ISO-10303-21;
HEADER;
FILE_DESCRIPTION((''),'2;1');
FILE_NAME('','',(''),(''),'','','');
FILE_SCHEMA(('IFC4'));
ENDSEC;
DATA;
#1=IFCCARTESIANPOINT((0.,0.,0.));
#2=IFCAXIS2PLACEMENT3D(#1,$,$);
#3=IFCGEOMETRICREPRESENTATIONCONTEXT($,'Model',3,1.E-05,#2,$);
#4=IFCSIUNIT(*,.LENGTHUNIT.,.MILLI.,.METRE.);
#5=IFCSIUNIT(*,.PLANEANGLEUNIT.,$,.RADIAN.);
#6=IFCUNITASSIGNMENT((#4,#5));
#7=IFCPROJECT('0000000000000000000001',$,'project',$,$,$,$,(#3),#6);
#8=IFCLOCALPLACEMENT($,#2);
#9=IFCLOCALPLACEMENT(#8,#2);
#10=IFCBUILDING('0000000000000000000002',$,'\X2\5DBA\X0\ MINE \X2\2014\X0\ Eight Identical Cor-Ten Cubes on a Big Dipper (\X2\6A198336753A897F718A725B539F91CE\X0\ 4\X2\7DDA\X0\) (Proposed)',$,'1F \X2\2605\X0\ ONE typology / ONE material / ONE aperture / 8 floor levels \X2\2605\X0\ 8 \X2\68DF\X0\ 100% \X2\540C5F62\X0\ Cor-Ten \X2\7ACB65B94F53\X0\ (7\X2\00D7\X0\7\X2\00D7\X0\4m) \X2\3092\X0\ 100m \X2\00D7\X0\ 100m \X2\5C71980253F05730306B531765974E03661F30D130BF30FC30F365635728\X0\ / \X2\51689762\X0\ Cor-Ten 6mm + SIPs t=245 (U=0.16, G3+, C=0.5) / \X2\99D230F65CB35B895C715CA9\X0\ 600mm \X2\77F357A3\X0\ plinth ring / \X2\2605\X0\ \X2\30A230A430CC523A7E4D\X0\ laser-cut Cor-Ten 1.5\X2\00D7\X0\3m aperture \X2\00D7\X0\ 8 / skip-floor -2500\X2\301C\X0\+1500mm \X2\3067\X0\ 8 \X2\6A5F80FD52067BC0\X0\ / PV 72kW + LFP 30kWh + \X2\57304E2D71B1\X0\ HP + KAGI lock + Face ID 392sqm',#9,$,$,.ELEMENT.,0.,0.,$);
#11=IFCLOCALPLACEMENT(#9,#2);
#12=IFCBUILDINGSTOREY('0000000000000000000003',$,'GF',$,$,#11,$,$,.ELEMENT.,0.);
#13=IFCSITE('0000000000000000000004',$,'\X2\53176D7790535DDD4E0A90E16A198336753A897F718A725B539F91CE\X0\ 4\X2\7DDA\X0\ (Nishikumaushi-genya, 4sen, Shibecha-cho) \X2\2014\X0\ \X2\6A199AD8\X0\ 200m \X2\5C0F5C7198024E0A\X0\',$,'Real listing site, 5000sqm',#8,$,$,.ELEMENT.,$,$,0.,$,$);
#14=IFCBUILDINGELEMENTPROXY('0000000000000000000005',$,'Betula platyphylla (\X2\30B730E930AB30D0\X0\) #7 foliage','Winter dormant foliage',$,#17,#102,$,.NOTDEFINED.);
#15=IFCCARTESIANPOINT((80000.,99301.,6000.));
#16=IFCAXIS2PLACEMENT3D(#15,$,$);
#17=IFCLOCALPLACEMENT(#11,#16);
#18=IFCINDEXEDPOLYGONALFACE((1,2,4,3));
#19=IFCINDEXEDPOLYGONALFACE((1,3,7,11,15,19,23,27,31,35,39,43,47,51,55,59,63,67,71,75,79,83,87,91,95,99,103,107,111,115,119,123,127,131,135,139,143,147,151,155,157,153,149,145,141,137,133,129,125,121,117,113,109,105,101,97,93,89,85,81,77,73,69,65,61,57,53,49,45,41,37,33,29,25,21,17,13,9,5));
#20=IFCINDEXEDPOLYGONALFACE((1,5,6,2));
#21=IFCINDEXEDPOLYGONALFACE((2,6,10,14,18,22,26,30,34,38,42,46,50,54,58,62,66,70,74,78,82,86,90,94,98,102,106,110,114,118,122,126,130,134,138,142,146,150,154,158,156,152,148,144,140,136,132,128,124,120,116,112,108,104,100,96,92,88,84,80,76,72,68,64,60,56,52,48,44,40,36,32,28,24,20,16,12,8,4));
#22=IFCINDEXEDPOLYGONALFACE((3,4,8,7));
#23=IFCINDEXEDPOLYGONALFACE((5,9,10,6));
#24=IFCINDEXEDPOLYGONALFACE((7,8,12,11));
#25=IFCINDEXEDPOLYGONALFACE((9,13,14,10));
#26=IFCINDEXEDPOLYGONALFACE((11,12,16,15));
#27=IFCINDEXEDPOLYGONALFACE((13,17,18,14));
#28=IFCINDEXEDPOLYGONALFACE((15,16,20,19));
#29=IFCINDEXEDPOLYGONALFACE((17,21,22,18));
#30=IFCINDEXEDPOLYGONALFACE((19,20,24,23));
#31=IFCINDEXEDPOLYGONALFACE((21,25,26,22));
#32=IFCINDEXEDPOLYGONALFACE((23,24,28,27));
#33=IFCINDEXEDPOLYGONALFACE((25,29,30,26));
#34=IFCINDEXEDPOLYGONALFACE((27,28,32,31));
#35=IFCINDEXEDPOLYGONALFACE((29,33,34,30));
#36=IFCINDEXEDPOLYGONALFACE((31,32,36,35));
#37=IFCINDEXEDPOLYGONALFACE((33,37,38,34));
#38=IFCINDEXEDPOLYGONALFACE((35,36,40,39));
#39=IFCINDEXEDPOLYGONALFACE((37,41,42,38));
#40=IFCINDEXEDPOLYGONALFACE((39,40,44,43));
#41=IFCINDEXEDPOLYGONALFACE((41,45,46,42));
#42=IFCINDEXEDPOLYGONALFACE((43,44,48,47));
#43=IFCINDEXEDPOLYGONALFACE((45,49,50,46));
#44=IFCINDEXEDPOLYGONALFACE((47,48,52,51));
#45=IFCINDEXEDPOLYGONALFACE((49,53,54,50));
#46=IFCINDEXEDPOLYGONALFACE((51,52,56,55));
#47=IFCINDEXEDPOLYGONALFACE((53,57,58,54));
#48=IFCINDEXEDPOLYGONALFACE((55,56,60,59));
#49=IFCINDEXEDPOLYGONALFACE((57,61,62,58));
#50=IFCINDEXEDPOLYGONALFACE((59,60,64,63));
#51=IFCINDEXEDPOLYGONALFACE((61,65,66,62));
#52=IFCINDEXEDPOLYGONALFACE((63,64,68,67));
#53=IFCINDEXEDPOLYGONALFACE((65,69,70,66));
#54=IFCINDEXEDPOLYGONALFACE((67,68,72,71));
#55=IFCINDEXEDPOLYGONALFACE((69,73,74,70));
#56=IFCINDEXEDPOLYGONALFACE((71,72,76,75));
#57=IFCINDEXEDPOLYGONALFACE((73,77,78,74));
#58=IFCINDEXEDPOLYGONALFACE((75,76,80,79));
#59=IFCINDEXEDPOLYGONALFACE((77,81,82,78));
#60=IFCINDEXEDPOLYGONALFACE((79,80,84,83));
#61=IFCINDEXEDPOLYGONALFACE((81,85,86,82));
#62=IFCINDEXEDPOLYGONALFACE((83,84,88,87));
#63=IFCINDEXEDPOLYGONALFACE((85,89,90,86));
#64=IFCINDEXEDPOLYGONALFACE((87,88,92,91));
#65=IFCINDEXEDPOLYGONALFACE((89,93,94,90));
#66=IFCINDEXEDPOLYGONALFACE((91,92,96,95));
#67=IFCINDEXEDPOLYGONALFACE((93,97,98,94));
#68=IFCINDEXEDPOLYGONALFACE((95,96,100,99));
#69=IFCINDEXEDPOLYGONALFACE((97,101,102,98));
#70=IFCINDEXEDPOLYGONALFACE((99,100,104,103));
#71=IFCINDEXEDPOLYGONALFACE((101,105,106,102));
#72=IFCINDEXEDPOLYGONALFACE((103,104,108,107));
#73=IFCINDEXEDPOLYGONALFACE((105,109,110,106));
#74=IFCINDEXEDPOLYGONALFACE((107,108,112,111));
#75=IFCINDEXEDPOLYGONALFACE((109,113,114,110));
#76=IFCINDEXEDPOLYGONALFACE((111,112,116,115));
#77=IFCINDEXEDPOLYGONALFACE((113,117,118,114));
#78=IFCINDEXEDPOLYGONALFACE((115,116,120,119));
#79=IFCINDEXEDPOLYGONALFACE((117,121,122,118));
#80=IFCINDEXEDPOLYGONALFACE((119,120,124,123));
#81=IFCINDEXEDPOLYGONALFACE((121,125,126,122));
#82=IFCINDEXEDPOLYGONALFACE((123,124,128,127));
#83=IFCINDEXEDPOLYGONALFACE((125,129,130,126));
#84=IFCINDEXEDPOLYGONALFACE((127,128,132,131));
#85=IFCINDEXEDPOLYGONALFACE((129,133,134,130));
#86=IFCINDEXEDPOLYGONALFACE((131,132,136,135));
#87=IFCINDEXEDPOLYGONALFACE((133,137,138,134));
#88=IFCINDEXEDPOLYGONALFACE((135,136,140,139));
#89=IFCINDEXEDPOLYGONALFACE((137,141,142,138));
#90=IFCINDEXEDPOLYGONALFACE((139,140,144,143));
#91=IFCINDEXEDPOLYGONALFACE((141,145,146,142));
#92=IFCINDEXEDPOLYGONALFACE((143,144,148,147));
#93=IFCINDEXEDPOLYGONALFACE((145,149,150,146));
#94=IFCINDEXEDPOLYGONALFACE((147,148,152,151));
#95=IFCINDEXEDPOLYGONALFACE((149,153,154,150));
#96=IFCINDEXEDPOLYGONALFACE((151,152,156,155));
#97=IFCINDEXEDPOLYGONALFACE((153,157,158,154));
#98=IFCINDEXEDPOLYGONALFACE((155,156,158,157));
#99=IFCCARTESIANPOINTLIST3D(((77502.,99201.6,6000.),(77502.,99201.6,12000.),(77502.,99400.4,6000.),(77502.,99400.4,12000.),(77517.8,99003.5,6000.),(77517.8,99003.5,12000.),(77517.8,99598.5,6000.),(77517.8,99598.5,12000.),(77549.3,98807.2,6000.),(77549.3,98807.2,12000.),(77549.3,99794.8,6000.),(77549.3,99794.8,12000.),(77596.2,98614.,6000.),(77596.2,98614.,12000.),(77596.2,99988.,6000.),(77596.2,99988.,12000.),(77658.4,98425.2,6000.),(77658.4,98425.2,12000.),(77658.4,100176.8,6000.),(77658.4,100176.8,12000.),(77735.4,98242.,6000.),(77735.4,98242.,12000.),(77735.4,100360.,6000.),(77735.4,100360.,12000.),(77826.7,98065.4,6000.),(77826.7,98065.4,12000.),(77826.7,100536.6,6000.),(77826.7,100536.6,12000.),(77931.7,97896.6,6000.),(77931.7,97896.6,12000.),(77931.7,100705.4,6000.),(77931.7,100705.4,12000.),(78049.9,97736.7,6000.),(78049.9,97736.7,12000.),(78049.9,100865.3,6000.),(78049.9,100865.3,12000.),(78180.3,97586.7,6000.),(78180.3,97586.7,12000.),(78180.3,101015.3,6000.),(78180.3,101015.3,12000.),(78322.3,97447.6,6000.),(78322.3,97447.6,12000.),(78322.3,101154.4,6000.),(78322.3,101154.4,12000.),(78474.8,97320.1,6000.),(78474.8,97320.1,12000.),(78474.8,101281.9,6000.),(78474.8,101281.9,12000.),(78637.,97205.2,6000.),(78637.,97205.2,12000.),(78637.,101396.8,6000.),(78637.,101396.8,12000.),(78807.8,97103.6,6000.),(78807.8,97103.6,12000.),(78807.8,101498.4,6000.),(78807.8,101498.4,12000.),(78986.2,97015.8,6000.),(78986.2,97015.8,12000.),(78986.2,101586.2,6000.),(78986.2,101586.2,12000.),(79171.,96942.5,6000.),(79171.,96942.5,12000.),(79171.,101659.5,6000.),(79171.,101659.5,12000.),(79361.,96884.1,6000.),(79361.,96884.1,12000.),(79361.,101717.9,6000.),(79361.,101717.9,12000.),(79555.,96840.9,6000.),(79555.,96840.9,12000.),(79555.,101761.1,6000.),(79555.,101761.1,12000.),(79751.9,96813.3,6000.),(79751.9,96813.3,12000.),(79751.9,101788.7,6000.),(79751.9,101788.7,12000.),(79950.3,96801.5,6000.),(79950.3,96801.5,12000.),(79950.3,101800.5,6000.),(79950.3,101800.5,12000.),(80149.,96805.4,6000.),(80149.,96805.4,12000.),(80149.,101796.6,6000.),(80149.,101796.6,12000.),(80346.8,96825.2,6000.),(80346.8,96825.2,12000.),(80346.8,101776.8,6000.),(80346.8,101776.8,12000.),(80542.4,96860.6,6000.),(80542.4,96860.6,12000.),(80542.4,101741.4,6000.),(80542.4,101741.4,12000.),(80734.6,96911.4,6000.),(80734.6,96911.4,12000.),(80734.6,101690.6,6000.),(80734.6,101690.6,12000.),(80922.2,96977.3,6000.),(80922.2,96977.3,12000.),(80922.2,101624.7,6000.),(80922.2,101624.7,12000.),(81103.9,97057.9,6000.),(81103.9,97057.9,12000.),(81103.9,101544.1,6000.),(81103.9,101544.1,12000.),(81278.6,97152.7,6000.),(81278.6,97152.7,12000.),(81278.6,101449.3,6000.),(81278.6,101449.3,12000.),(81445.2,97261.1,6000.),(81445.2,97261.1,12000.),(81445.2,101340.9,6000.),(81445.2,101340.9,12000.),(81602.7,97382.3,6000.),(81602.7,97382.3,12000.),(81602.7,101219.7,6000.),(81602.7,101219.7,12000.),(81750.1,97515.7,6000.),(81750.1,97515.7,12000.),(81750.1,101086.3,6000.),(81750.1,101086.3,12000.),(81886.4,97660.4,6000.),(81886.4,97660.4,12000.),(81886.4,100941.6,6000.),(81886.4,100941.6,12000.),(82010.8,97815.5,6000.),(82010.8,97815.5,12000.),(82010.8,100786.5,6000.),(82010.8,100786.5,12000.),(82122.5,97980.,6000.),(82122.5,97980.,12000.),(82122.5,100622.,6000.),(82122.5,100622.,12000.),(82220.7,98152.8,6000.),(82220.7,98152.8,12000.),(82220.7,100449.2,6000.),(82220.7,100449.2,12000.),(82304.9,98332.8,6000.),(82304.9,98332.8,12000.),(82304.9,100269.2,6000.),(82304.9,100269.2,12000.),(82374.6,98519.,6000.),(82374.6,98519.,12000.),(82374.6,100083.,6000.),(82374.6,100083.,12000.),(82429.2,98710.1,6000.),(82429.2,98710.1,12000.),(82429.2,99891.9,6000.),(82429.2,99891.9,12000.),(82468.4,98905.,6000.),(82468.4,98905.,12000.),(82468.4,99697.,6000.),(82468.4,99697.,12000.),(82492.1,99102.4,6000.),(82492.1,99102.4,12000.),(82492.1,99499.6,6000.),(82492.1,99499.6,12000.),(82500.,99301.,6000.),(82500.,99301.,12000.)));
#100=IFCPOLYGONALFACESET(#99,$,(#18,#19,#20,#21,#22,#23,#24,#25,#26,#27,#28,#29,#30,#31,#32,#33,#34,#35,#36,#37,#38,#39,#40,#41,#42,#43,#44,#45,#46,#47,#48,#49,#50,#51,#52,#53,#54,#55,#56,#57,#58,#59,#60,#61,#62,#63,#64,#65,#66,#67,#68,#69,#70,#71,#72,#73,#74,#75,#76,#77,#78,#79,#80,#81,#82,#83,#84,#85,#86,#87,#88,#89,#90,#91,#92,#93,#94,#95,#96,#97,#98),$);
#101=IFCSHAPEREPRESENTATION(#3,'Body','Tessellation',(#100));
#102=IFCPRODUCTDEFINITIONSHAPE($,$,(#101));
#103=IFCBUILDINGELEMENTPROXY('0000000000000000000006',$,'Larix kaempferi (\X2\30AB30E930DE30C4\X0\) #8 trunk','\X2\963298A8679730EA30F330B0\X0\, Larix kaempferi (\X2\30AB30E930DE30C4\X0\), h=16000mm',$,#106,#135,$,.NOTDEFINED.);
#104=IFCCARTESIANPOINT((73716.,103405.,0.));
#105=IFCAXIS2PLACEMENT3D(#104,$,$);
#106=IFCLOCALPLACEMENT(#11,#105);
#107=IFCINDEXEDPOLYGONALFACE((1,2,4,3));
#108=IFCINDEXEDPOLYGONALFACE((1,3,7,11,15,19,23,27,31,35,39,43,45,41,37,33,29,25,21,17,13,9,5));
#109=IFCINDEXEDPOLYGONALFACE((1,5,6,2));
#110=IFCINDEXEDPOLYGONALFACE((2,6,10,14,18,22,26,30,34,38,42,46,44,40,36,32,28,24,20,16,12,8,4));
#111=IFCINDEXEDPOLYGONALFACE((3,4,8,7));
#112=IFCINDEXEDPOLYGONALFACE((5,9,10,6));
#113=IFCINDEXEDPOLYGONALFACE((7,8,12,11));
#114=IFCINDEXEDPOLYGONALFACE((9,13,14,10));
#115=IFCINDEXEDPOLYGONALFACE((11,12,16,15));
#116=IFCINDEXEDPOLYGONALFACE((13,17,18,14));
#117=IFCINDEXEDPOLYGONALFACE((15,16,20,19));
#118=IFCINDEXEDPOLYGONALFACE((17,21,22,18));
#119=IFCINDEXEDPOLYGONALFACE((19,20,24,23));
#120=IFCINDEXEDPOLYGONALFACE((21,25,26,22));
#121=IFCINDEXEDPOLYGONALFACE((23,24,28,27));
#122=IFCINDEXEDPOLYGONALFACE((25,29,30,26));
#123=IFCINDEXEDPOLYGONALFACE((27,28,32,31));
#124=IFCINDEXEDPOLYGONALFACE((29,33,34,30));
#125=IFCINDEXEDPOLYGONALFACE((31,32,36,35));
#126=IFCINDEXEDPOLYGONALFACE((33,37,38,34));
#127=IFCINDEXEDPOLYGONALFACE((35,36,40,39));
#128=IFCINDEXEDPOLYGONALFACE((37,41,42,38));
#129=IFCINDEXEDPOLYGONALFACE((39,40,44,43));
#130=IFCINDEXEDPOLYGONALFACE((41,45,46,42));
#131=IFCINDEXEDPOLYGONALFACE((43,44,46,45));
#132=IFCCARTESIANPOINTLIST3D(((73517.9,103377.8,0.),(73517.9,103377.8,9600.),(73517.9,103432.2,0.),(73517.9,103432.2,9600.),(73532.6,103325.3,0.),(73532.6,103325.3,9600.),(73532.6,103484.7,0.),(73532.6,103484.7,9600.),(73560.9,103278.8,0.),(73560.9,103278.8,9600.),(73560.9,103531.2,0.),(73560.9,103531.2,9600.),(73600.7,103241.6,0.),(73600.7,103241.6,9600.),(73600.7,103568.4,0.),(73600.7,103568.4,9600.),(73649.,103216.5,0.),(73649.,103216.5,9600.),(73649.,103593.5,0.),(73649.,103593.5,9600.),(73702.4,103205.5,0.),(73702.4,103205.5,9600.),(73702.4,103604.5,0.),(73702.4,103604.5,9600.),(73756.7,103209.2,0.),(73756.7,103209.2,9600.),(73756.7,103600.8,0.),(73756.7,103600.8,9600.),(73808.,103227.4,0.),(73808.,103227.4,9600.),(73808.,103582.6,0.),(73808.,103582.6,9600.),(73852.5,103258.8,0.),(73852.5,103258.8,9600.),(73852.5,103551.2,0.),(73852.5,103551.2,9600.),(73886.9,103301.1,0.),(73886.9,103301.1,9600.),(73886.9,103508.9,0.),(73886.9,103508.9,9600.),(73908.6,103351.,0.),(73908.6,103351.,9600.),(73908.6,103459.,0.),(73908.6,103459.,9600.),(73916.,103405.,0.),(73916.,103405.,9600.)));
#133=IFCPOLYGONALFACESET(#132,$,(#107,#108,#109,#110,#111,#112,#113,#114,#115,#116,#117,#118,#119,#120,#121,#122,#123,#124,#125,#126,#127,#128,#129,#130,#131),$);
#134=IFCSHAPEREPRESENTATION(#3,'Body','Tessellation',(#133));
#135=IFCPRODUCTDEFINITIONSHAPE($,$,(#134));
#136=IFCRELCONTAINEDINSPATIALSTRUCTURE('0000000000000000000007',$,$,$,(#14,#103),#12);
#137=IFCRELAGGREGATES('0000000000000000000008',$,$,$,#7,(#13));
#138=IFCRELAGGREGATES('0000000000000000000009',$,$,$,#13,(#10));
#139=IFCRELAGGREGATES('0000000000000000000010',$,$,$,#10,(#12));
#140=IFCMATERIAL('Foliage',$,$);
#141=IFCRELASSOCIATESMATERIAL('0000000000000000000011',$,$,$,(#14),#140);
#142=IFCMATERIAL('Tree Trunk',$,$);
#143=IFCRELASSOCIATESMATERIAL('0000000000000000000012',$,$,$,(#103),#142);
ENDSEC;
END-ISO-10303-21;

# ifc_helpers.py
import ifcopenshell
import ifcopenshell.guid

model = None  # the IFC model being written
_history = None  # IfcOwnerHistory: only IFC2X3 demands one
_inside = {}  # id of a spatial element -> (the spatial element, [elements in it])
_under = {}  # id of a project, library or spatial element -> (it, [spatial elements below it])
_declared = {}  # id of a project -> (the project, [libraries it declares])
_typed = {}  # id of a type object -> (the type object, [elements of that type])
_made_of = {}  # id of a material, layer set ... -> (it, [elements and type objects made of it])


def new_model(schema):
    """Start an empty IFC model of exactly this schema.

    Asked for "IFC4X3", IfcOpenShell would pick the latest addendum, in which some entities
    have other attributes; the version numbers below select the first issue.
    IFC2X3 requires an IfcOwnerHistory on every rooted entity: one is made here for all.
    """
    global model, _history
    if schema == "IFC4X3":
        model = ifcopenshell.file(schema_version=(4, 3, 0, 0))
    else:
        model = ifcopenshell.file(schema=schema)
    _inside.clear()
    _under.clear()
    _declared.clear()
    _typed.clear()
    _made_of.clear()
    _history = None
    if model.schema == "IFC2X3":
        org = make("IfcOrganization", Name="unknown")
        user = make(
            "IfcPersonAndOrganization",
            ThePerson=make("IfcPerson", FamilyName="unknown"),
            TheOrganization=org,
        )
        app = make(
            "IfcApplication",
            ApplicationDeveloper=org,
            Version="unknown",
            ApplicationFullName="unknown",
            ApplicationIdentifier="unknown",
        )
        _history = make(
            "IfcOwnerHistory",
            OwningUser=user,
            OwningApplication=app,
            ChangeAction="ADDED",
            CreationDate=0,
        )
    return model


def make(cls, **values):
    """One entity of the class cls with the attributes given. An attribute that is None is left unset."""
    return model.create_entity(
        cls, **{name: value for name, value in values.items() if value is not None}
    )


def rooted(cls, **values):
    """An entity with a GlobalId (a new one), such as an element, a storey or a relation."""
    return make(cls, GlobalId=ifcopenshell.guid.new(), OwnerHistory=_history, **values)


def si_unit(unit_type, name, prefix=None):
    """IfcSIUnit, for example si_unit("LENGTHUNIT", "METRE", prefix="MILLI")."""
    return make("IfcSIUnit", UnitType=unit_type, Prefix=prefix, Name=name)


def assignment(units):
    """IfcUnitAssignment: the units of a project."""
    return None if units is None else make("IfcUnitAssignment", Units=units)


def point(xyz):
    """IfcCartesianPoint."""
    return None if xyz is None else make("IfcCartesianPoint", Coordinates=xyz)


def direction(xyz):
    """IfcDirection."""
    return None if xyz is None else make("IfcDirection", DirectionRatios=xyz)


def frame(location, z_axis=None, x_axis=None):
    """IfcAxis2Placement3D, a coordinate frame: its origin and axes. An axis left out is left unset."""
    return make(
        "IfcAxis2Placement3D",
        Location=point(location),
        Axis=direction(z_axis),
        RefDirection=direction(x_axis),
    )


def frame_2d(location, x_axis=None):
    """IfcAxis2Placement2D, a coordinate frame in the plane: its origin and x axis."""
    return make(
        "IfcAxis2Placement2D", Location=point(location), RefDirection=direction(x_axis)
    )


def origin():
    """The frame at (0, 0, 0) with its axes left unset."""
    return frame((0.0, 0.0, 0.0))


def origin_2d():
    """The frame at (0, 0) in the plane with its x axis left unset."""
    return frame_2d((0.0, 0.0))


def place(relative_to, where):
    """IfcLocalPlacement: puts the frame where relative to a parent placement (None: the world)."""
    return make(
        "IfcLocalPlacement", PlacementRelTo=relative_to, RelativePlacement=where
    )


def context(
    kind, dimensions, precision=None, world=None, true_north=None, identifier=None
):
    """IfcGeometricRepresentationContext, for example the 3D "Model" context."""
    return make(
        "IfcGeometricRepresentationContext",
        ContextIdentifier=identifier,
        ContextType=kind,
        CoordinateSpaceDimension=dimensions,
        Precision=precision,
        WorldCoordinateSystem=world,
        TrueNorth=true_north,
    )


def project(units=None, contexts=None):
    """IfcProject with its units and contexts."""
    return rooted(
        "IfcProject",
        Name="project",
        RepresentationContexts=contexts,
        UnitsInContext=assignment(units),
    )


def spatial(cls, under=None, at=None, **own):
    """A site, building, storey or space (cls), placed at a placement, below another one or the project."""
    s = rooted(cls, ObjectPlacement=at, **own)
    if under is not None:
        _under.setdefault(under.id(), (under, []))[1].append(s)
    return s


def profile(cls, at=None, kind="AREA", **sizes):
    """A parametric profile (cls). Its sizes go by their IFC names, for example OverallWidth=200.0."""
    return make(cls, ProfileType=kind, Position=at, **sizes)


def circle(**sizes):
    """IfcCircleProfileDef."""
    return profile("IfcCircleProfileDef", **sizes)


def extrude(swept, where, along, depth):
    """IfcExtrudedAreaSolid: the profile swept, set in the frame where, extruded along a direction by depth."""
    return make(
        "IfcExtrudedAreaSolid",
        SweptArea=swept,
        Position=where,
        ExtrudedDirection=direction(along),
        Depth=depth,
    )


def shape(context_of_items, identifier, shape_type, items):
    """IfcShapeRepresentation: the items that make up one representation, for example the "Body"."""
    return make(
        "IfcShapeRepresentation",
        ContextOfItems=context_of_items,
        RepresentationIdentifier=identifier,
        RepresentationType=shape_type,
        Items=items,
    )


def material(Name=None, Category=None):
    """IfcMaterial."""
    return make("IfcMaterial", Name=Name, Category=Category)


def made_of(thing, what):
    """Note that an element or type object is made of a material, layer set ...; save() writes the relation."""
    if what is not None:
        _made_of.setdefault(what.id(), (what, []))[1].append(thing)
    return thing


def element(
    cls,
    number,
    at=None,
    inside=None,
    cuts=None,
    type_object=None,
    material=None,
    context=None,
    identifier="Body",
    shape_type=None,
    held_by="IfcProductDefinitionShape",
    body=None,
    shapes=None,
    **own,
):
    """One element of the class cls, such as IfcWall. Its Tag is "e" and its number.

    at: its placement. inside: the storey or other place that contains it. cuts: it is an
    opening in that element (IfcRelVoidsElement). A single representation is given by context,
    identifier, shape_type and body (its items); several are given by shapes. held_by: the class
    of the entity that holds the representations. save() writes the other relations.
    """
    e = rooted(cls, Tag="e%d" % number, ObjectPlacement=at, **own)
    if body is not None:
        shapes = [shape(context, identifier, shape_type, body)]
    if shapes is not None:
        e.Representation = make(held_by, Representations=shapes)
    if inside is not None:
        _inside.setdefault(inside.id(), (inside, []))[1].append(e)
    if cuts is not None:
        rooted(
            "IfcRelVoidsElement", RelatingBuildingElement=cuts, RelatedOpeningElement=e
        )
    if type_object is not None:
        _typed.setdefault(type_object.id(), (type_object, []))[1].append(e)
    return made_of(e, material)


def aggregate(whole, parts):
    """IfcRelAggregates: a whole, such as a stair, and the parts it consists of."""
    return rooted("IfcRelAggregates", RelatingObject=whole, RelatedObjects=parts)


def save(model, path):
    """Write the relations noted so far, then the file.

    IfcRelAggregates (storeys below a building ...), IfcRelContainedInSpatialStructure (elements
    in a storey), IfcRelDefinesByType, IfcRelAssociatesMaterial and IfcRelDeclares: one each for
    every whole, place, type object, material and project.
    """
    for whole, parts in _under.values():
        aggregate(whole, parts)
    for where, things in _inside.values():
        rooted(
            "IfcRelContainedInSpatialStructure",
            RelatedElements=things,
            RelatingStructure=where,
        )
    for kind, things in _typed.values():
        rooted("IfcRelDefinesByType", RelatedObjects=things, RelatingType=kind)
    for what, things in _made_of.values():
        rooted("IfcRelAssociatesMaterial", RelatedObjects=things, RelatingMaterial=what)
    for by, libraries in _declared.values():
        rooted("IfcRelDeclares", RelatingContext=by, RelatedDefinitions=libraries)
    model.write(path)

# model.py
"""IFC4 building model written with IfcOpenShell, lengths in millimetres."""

from ifc_helpers import new_model, si_unit, frame, origin, origin_2d, place, context, project, spatial, circle, extrude, material, element, save


model = new_model("IFC4")

# Units and contexts
model_context = context("Model", 3, precision=1e-05, world=origin())
ifc_project = project(units=[si_unit("LENGTHUNIT", "METRE", prefix="MILLI"), si_unit("PLANEANGLEUNIT", "RADIAN")], contexts=[model_context])

# Site, building, storey
site_placement = place(None, origin())
site = spatial("IfcSite", under=ifc_project, at=site_placement, Name="北海道川上郡標茶町西熊牛原野 4線 (Nishikumaushi-genya, 4sen, Shibecha-cho) — 標高 200m 小山頂上", ObjectType="Real listing site, 5000sqm", CompositionType="ELEMENT", RefElevation=0.0)
building_placement = place(site_placement, origin())
building = spatial("IfcBuilding", under=site, at=building_placement, Name="嶺 MINE — Eight Identical Cor-Ten Cubes on a Big Dipper (標茶町西熊牛原野 4線) (Proposed)", ObjectType="1F ★ ONE typology / ONE material / ONE aperture / 8 floor levels ★ 8 棟 100% 同形 Cor-Ten 立方体 (7×7×4m) を 100m × 100m 山頂台地に北斗七星パターン散在 / 全面 Cor-Ten 6mm + SIPs t=245 (U=0.16, G3+, C=0.5) / 駒ヶ岳安山岩 600mm 石垣 plinth ring / ★ アイヌ刺繍 laser-cut Cor-Ten 1.5×3m aperture × 8 / skip-floor -2500〜+1500mm で 8 機能分節 / PV 72kW + LFP 30kWh + 地中熱 HP + KAGI lock + Face ID 392sqm", CompositionType="ELEMENT", ElevationOfRefHeight=0.0, ElevationOfTerrain=0.0)
storey_placement = place(building_placement, origin())
storey = spatial("IfcBuildingStorey", under=building, at=storey_placement, Name="GF", CompositionType="ELEMENT", Elevation=0.0)

# Building element proxies
ifc_material_1 = material(Name="Tree Trunk")
ifc_material_2 = material(Name="Foliage")
proxy_1_placement = place(storey_placement, frame((80000.0, 99301.0, 6000.0)))
element("IfcBuildingElementProxy", 1, at=proxy_1_placement, inside=storey, material=ifc_material_2, Name="Betula platyphylla (シラカバ) #7 foliage", Description="Winter dormant foliage", PredefinedType="NOTDEFINED", context=model_context, shape_type="SweptSolid", body=[
    extrude(circle(Radius=2500.0, at=origin_2d()), frame((80000.0, 99301.0, 6000.0)), (0.0, 0.0, 1.0), 6000.0),
])
proxy_2_placement = place(storey_placement, frame((73716.0, 103405.0, 0.0)))
element("IfcBuildingElementProxy", 2, at=proxy_2_placement, inside=storey, material=ifc_material_1, Name="Larix kaempferi (カラマツ) #8 trunk", Description="防風林リング, Larix kaempferi (カラマツ), h=16000mm", PredefinedType="NOTDEFINED", context=model_context, shape_type="SweptSolid", body=[
    extrude(circle(Radius=200.0, at=origin_2d()), frame((73716.0, 103405.0, 0.0)), (0.0, 0.0, 1.0), 9600.0),
])

save(model, "model.ifc")
